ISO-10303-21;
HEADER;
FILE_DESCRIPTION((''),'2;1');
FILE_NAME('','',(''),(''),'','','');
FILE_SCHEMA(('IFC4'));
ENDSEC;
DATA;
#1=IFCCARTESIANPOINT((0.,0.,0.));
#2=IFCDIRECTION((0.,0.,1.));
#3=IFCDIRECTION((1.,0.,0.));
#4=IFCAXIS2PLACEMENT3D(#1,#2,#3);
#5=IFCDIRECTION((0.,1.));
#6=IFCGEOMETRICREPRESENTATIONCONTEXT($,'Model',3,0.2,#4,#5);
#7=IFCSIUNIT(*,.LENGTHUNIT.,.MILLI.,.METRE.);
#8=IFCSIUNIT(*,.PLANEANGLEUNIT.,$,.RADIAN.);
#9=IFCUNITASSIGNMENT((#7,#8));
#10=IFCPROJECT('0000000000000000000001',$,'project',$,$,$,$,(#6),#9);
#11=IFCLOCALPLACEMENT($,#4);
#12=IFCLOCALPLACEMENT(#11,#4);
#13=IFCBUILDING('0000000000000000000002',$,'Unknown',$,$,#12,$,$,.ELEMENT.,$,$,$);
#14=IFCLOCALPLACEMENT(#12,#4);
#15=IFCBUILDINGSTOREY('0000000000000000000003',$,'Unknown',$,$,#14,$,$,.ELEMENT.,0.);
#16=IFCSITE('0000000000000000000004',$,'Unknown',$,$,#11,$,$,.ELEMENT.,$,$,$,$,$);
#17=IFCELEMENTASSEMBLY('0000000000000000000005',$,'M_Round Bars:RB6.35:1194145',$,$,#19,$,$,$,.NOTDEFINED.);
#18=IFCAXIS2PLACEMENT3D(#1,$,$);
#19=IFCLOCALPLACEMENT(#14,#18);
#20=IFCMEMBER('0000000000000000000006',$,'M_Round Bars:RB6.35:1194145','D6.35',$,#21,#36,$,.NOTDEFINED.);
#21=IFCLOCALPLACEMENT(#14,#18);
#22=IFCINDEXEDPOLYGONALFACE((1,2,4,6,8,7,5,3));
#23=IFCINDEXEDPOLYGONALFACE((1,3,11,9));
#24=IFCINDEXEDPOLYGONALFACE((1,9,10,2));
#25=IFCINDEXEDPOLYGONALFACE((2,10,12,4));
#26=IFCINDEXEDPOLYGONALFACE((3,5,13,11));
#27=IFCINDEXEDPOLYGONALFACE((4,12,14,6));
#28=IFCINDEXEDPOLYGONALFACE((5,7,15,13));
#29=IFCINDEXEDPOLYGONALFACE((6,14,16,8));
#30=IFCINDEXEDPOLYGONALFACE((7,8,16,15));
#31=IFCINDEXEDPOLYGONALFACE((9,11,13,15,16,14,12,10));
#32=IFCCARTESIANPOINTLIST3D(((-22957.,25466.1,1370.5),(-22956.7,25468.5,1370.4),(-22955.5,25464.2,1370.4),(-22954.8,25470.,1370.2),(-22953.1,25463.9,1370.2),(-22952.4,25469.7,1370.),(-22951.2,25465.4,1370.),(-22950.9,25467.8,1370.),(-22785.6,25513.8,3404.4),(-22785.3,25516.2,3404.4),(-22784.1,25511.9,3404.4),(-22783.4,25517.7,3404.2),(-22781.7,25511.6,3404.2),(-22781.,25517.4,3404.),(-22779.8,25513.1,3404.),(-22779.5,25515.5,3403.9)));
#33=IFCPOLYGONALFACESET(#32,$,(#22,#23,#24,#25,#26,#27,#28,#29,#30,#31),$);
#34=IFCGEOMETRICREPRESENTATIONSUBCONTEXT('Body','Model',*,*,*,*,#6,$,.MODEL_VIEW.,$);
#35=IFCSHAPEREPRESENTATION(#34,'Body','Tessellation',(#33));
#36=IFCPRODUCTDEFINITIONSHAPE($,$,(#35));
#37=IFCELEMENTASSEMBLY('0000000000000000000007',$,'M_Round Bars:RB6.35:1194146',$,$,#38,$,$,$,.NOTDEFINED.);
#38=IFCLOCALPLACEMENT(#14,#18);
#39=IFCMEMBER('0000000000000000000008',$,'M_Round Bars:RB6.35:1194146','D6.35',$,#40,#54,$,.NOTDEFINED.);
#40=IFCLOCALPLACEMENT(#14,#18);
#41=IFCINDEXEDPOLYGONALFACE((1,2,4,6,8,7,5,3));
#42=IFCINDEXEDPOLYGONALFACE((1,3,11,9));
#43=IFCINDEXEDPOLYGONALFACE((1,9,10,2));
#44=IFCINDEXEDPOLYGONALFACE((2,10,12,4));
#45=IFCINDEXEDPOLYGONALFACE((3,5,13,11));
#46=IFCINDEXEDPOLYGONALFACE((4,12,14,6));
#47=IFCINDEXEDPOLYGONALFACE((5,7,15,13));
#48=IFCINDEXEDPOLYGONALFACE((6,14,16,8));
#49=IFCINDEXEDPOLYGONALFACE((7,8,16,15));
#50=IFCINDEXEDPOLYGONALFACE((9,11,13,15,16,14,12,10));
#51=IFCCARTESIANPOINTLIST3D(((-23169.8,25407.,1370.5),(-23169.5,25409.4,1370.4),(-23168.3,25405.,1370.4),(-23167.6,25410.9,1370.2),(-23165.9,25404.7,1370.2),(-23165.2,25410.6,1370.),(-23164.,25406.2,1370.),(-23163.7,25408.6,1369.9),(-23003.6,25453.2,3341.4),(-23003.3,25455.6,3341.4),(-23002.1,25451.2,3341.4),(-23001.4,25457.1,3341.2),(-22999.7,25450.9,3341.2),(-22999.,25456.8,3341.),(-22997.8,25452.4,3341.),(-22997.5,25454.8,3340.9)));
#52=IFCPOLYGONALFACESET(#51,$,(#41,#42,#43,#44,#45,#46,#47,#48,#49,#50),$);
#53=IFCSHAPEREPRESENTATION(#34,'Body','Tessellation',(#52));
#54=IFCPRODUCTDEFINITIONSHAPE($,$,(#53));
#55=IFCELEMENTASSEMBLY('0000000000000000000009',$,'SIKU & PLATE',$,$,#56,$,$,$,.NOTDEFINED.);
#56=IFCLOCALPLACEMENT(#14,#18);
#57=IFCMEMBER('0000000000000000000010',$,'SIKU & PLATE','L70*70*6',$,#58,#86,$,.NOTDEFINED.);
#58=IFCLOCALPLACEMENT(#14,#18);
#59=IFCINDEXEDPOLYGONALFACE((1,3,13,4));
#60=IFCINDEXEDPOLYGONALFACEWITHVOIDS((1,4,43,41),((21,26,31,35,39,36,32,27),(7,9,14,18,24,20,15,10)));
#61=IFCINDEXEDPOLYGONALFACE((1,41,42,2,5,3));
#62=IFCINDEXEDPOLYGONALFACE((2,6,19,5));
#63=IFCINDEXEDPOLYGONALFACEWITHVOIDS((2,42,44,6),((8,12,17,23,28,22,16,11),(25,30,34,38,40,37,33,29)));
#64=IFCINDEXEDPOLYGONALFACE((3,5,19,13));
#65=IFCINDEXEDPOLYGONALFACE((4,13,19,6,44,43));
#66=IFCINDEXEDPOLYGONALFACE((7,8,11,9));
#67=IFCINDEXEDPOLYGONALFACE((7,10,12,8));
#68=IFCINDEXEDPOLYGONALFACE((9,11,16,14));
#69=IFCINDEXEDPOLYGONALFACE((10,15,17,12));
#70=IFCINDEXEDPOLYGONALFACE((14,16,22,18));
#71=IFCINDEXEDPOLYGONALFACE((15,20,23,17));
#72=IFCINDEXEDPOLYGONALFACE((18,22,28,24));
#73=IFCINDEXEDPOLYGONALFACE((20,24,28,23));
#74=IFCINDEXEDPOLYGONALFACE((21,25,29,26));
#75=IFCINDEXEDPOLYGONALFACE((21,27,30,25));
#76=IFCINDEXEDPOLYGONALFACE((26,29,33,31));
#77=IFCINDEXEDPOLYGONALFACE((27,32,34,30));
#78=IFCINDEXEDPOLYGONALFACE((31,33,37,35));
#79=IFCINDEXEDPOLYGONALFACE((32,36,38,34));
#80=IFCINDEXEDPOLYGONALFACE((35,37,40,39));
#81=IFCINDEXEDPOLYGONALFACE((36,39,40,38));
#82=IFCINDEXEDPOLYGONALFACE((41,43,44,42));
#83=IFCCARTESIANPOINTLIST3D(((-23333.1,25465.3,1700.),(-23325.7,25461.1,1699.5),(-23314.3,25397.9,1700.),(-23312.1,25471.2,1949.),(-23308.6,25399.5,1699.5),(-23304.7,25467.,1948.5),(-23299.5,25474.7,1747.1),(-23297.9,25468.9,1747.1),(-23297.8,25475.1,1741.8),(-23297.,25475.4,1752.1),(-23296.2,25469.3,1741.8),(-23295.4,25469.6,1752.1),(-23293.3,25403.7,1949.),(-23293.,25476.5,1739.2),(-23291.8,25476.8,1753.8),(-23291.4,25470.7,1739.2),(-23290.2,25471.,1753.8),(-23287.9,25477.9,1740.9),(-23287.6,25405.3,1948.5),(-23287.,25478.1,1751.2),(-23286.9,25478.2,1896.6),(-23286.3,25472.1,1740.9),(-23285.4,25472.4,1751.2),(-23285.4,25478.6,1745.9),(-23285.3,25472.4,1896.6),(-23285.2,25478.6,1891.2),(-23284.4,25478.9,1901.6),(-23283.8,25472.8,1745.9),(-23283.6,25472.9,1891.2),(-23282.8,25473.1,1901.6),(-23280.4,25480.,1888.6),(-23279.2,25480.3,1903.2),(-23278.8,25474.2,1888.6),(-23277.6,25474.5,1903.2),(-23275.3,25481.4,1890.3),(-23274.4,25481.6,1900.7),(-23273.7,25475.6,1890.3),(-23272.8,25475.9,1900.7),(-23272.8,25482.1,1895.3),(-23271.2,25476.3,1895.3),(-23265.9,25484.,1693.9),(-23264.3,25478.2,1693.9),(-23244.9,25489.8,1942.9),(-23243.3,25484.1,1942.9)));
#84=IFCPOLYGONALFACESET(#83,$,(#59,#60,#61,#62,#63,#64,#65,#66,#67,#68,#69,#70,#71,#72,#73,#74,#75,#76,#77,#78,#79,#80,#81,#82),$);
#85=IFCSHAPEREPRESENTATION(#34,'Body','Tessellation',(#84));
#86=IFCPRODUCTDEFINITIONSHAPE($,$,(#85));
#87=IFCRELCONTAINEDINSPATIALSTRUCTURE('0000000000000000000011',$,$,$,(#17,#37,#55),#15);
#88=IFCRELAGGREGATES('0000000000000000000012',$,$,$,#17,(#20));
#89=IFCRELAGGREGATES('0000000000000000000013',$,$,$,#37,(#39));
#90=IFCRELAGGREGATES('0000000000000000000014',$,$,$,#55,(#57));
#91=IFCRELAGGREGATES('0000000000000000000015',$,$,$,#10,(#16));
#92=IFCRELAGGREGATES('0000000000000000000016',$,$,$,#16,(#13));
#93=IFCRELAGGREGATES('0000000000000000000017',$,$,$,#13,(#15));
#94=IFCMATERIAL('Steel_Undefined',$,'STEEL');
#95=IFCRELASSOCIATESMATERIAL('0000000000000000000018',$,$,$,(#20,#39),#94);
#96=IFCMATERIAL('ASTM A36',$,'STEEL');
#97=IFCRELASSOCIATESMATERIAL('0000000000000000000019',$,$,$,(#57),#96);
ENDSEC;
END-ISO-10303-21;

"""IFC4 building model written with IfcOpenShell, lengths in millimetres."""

from ifc_helpers import new_model, si_unit, direction, frame, origin_with_axes, place, context, subcontext, project, spatial, line, indexed_curve, outline, extrude, material, element, aggregate, save


model = new_model("IFC4")

# Units and contexts
model_context = context("Model", 3, precision=0.2, world=origin_with_axes(), true_north=direction((0.0, 1.0)))
body_context = subcontext(model_context, "Body", "Model", "MODEL_VIEW")
ifc_project = project(units=[si_unit("LENGTHUNIT", "METRE", prefix="MILLI"), si_unit("PLANEANGLEUNIT", "RADIAN")], contexts=[model_context])

# Site, building, storey
site_placement = place(None, origin_with_axes())
site = spatial("IfcSite", under=ifc_project, at=site_placement, Name="Unknown", CompositionType="ELEMENT")
building_placement = place(site_placement, origin_with_axes())
building = spatial("IfcBuilding", under=site, at=building_placement, Name="Unknown", CompositionType="ELEMENT")
storey_placement = place(building_placement, origin_with_axes())
storey = spatial("IfcBuildingStorey", under=building, at=storey_placement, Name="Unknown", CompositionType="ELEMENT", Elevation=0.0)

# Element assemblies, members
ifc_material_1 = material(Name="Steel_Undefined", Category="STEEL")
assembly_1_placement = place(storey_placement, frame((-22954.0, 25467.0, 1370.2), z_axis=(-0.267944, 0.963434, 0.0), x_axis=(0.083969, 0.023353, 0.996195)))
assembly_1 = element("IfcElementAssembly", 1, at=assembly_1_placement, inside=storey, Name="M_Round Bars:RB6.35:1194145", PredefinedType="NOTDEFINED")
member_1_placement = place(assembly_1_placement, origin_with_axes())
member_1 = element("IfcMember", 2, at=member_1_placement, material=ifc_material_1, Name="M_Round Bars:RB6.35:1194145", Description="D6.35", PredefinedType="NOTDEFINED", context=body_context, shape_type="SolidModel", body=[
    extrude(outline(indexed_curve([(3.2, 0.0), (2.2, 2.2), (0.0, 3.2), (-2.2, 2.2), (-3.2, 0.0), (-2.2, -2.2), (0.0, -3.2), (2.2, -2.2)], segments=[line(1, 2, 3, 4, 5, 6, 7, 8, 1)])), frame((0.0, 0.0, 0.0), z_axis=(-1.0, 0.0, 0.0), x_axis=(0.0, 0.0, 1.0)), (0.0, 0.0, -1.0), 2041.7),
])
aggregate(assembly_1, [member_1])
assembly_2_placement = place(storey_placement, frame((-23166.7, 25407.8, 1370.2), z_axis=(-0.267944, 0.963434, 0.0), x_axis=(0.083969, 0.023353, 0.996195)))
assembly_2 = element("IfcElementAssembly", 3, at=assembly_2_placement, inside=storey, Name="M_Round Bars:RB6.35:1194146", PredefinedType="NOTDEFINED")
member_2_placement = place(assembly_2_placement, origin_with_axes())
member_2 = element("IfcMember", 4, at=member_2_placement, material=ifc_material_1, Name="M_Round Bars:RB6.35:1194146", Description="D6.35", PredefinedType="NOTDEFINED", context=body_context, shape_type="SolidModel", body=[
    extrude(outline(indexed_curve([(3.2, 0.0), (2.2, 2.2), (0.0, 3.2), (-2.2, 2.2), (-3.2, 0.0), (-2.2, -2.2), (0.0, -3.2), (2.2, -2.2)], segments=[line(1, 2, 3, 4, 5, 6, 7, 8, 1)])), frame((0.0, 0.0, 0.0), z_axis=(-1.0, 0.0, 0.0), x_axis=(0.0, 0.0, 1.0)), (0.0, 0.0, -1.0), 1978.5),
])
aggregate(assembly_2, [member_2])

# Element assembly, member, voiding features
assembly_3_placement = place(storey_placement, frame((-23269.1, 25446.8, 1946.0), z_axis=(0.267944, -0.963434, 0.0), x_axis=(-0.083973, -0.023354, -0.996194)))
assembly_3 = element("IfcElementAssembly", 5, at=assembly_3_placement, inside=storey, Name="SIKU & PLATE", PredefinedType="NOTDEFINED")
ifc_material_2 = material(Name="ASTM A36", Category="STEEL")
member_3_placement = place(assembly_3_placement, origin_with_axes())
member_3 = element("IfcMember", 6, at=member_3_placement, material=ifc_material_2, Name="SIKU & PLATE", Description="L70*70*6", PredefinedType="NOTDEFINED", context=body_context, shape_type="SolidModel", body=[
    extrude(outline(indexed_curve([(-35.0, -35.0), (35.0, -35.0), (35.0, -29.0), (-29.0, -29.0), (-29.0, 35.0), (-35.0, 35.0)], segments=[line(1, 2, 3, 4, 5, 6, 1)])), frame((0.0, 0.0, 0.0), z_axis=(-1.0, 0.0, 0.0), x_axis=(0.0, 0.0, 1.0)), (0.0, 0.0, -1.0), 250.0),
])
voiding_feature_1_placement = place(member_3_placement, frame((200.0, 3.0, -35.5), z_axis=(-1.0, 0.0, 0.0), x_axis=(0.0, 0.0, 1.0)))
element("IfcVoidingFeature", 7, at=voiding_feature_1_placement, cuts=member_3, Name="BEAM", PredefinedType="HOLE", context=body_context, shape_type="SolidModel", body=[
    extrude(outline(indexed_curve([(7.4, 0.0), (5.2, 5.2), (0.0, 7.4), (-5.2, 5.2), (-7.4, 0.0), (-5.2, -5.2), (0.0, -7.4), (5.2, -5.2)], segments=[line(1, 2, 3, 4, 5, 6, 7, 8, 1)])), frame((0.0, 0.0, 0.0), z_axis=(-1.0, 0.0, 0.0), x_axis=(0.0, 0.0, 1.0)), (0.0, 0.0, -1.0), 7.0),
])
voiding_feature_2_placement = place(member_3_placement, frame((50.0, 3.0, -35.5), z_axis=(-1.0, 0.0, 0.0), x_axis=(0.0, 0.0, 1.0)))
element("IfcVoidingFeature", 8, at=voiding_feature_2_placement, cuts=member_3, Name="BEAM", PredefinedType="HOLE", context=body_context, shape_type="SolidModel", body=[
    extrude(outline(indexed_curve([(7.4, 0.0), (5.2, 5.2), (0.0, 7.4), (-5.2, 5.2), (-7.4, 0.0), (-5.2, -5.2), (0.0, -7.4), (5.2, -5.2)], segments=[line(1, 2, 3, 4, 5, 6, 7, 8, 1)])), frame((0.0, 0.0, 0.0), z_axis=(-1.0, 0.0, 0.0), x_axis=(0.0, 0.0, 1.0)), (0.0, 0.0, -1.0), 7.0),
])
aggregate(assembly_3, [member_3])

save(model, "model.ifc")
